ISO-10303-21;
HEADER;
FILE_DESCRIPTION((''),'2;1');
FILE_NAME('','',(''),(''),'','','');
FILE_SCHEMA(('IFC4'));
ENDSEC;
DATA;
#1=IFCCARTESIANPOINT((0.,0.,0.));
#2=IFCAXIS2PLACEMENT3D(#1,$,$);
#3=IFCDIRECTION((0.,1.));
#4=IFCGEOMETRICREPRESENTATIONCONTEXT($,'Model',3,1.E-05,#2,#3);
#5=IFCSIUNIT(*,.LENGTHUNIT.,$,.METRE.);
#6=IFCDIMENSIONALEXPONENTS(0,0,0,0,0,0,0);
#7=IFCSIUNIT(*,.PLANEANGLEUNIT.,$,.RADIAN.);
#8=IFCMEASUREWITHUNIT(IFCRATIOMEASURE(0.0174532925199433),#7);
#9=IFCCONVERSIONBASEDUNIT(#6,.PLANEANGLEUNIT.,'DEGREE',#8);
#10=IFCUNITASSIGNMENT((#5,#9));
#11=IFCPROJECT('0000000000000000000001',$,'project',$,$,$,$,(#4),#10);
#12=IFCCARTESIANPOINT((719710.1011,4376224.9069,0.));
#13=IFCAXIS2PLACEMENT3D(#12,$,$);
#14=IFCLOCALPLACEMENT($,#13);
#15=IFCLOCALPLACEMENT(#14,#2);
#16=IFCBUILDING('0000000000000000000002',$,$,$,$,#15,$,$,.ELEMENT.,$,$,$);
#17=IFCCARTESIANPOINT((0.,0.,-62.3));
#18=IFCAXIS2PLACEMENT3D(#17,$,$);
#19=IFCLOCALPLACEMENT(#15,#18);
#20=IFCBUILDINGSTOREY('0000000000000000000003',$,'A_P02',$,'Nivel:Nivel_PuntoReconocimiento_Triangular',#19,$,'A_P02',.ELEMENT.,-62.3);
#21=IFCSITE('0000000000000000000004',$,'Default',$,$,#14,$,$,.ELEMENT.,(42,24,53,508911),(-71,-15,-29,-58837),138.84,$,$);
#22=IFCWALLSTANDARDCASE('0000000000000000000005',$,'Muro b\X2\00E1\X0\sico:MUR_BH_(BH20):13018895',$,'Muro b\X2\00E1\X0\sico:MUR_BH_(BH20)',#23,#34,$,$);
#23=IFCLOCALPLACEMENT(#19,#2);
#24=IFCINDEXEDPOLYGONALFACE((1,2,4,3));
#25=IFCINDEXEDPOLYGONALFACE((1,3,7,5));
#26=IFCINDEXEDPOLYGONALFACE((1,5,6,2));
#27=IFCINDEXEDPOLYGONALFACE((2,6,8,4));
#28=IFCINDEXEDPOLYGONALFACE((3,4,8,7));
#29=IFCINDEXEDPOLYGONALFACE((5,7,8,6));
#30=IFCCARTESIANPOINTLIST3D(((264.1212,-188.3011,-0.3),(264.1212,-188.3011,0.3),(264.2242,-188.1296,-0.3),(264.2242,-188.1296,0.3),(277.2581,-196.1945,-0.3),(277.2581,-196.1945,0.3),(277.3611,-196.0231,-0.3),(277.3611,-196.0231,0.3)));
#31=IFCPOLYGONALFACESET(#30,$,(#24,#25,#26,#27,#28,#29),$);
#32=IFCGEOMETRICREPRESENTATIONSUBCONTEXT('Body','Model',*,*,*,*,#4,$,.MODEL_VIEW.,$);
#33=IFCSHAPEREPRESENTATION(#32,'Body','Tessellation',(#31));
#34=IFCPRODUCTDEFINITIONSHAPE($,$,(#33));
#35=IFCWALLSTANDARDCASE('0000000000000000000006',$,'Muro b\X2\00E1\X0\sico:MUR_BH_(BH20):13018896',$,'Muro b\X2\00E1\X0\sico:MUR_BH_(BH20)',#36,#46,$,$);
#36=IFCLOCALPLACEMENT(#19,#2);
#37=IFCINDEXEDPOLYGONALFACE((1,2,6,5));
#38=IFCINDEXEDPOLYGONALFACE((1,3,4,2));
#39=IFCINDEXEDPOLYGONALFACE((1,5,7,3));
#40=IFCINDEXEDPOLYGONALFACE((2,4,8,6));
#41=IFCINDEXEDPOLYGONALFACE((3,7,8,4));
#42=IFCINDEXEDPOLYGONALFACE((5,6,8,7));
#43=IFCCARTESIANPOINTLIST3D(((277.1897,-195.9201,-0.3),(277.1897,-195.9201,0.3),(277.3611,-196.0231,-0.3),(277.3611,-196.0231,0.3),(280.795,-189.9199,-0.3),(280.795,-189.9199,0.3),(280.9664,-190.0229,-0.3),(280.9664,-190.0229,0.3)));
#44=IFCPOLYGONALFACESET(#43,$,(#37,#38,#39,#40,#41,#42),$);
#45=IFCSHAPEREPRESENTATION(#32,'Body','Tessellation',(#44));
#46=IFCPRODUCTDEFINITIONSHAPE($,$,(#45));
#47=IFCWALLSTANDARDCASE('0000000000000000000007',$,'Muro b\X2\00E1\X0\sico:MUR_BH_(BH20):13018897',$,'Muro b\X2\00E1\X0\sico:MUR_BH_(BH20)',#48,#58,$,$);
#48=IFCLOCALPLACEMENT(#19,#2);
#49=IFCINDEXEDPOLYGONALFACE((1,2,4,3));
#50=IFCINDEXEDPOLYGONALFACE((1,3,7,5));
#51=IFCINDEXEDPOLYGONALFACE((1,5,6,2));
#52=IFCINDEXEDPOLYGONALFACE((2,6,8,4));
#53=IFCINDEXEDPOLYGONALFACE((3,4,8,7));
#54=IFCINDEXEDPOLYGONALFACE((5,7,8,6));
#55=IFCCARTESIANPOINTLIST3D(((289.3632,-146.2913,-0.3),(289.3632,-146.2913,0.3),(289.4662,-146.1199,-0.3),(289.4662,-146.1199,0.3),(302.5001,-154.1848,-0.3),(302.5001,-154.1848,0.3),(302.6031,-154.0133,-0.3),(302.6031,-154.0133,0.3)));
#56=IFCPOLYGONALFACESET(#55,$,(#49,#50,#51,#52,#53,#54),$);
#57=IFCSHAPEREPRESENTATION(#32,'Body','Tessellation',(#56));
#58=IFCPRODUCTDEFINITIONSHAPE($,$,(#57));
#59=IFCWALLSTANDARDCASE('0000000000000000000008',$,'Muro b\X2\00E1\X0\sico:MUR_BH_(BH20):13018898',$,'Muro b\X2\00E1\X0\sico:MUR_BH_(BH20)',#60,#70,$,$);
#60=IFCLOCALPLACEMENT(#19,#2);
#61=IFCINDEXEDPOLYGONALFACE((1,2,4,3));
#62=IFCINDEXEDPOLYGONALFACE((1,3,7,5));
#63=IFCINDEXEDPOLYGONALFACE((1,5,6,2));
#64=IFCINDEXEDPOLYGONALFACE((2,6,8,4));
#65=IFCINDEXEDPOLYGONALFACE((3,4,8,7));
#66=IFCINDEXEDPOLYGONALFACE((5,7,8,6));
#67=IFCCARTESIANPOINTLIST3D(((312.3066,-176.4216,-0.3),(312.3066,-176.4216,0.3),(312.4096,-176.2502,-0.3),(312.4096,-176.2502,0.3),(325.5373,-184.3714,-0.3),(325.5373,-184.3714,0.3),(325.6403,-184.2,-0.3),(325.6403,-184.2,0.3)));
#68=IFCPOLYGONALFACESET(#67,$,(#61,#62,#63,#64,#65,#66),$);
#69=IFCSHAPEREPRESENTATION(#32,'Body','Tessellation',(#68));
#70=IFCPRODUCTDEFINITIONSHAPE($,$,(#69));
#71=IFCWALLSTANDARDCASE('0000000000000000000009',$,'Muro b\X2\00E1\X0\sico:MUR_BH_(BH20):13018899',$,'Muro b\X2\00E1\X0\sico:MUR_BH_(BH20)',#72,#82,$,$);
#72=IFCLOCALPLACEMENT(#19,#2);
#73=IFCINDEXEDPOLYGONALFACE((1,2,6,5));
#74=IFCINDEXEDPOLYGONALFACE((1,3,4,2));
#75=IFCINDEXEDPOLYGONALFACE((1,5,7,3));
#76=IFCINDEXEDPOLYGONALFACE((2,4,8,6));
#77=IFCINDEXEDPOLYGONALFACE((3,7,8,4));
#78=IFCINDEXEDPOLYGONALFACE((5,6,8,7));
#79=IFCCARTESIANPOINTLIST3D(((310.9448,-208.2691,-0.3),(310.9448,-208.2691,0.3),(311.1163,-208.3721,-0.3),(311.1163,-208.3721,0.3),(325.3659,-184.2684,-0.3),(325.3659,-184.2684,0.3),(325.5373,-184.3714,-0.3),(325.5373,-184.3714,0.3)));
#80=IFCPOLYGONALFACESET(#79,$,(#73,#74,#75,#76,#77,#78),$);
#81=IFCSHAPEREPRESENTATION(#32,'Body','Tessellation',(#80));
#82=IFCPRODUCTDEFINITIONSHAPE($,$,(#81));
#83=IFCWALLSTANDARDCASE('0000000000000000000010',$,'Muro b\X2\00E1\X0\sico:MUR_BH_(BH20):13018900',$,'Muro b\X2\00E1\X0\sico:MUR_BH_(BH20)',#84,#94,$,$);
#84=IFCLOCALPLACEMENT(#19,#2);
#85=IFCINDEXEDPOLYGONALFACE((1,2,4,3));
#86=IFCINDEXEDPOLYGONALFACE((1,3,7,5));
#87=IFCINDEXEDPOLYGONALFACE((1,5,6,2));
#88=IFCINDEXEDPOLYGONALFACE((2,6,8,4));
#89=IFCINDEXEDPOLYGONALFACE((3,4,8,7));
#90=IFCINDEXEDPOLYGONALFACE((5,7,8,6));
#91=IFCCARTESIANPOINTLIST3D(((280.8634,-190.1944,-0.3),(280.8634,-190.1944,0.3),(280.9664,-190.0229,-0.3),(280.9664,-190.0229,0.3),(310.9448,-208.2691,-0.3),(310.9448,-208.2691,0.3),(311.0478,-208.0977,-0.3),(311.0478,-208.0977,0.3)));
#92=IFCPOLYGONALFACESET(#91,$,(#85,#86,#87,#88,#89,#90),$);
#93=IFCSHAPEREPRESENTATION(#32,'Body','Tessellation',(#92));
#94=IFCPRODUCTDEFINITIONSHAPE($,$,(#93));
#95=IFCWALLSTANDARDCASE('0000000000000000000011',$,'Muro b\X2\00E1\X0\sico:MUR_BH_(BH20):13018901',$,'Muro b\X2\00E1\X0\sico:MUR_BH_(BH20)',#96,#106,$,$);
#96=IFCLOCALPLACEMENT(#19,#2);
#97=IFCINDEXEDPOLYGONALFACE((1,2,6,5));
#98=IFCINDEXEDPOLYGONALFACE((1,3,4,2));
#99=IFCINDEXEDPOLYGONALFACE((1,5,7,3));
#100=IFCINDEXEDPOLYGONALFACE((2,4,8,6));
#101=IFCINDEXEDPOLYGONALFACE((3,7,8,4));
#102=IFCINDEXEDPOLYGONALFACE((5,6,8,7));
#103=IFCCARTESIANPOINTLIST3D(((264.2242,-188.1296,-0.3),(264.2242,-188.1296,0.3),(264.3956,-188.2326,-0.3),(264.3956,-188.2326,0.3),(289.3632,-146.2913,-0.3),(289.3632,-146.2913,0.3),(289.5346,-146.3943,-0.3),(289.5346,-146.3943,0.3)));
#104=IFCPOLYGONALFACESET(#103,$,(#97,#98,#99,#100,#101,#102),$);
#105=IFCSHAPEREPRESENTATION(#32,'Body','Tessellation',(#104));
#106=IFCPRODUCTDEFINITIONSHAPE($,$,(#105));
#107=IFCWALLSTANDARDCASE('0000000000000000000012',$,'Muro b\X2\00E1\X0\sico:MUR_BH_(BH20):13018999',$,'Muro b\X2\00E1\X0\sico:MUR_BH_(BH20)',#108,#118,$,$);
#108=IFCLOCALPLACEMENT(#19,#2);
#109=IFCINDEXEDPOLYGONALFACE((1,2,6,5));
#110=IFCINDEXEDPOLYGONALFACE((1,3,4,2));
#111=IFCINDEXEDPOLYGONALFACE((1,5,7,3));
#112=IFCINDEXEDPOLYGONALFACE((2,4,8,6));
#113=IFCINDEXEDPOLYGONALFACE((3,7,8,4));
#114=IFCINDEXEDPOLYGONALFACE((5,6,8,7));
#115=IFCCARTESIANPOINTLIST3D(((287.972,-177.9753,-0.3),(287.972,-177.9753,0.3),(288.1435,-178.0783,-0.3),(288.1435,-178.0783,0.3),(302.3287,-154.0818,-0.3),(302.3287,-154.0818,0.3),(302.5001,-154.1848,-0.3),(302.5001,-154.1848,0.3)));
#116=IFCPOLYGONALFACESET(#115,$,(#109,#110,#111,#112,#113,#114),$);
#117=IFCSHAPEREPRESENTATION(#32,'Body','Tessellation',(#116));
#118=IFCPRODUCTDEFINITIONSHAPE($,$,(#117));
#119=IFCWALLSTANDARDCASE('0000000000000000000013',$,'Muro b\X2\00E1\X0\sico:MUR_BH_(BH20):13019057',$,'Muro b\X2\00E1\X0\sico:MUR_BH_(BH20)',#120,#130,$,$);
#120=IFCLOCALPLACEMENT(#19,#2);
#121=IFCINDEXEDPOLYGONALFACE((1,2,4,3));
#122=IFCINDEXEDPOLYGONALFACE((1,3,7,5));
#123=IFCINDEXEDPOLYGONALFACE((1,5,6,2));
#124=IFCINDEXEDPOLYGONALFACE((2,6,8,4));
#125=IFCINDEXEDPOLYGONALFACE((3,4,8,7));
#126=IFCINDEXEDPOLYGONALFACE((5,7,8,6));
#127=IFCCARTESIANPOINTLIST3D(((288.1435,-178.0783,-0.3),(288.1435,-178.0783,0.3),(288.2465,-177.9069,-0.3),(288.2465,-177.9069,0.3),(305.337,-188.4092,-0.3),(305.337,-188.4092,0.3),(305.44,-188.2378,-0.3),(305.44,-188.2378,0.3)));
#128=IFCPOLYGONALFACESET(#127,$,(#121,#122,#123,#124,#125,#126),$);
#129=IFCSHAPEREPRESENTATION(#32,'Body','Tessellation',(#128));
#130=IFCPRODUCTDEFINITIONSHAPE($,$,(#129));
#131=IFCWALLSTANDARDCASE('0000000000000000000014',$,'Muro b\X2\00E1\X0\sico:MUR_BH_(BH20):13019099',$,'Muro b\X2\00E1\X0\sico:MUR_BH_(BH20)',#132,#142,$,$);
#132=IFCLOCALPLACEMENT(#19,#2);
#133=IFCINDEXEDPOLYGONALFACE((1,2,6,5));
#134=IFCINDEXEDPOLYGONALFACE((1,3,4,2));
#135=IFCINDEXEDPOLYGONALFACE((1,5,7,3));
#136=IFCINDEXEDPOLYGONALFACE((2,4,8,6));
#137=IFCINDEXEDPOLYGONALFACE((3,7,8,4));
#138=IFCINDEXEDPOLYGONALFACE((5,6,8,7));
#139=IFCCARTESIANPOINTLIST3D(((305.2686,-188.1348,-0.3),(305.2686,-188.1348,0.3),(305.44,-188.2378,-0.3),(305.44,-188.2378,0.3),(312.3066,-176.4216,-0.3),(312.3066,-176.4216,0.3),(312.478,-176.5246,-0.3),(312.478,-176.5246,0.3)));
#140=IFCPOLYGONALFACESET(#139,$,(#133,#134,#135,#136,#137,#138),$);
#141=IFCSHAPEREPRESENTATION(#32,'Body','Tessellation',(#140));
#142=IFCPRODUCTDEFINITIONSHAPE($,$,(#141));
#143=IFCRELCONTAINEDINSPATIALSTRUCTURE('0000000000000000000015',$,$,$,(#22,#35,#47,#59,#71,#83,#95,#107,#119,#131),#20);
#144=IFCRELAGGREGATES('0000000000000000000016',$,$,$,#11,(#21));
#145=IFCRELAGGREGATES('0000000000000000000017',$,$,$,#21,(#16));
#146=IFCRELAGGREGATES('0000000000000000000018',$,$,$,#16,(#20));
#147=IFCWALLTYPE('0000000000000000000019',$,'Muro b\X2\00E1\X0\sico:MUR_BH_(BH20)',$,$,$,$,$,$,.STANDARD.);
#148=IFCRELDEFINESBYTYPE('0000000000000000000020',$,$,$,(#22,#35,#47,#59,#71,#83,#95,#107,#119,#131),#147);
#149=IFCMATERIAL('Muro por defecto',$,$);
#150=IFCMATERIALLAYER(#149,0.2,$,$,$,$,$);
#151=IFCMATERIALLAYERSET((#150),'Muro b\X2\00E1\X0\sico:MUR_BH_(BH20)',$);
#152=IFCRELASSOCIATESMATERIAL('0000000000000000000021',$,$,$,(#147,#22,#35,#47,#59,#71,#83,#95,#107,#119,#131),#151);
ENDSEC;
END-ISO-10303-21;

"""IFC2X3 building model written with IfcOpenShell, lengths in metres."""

from ifc_helpers import new_model, entity, si_unit, converted_unit, direction, frame, frame_2d, origin, place, context, subcontext, project, spatial, rectangle, extrude, material, layer, layer_set, layer_usage, type_object, element, save


model = new_model("IFC2X3")

# Units and contexts
model_context = context("Model", 3, precision=1e-05, world=origin(), true_north=direction((0.0, 1.0)))
body_context = subcontext(model_context, "Body", "Model", "MODEL_VIEW")
ifc_project = project(units=[si_unit("LENGTHUNIT", "METRE"), converted_unit("PLANEANGLEUNIT", "DEGREE", entity("IfcRatioMeasure", 0.0174532925199433), si_unit("PLANEANGLEUNIT", "RADIAN"), dimensions=[0, 0, 0, 0, 0, 0, 0])], contexts=[model_context])

# Site, building, storey
site_placement = place(None, frame((719710.1011, 4376224.9069, 0.0)))
site = spatial("IfcSite", under=ifc_project, at=site_placement, Name="Default", CompositionType="ELEMENT", RefLatitude=(42, 24, 53, 508911), RefLongitude=(-71, -15, -29, -58837), RefElevation=138.84)
building_placement = place(site_placement, origin())
building = spatial("IfcBuilding", under=site, at=building_placement, CompositionType="ELEMENT")
storey_placement = place(building_placement, frame((0.0, 0.0, -62.3)))
storey = spatial("IfcBuildingStorey", under=building, at=storey_placement, Name="A_P02", ObjectType="Nivel:Nivel_PuntoReconocimiento_Triangular", LongName="A_P02", CompositionType="ELEMENT", Elevation=-62.3)

# Walls
ifc_material_1 = material(Name="Muro por defecto")
ifc_layer_1 = layer(ifc_material_1, 0.2)
ifc_layer_set_1 = layer_set([ifc_layer_1], Name="Muro básico:MUR_BH_(BH20)")
ifc_layer_usage_1 = layer_usage(ifc_layer_set_1, "AXIS2", "NEGATIVE", 0.1)
wall_type = type_object("IfcWallType", Name="Muro básico:MUR_BH_(BH20)", PredefinedType="STANDARD", material=ifc_layer_set_1)
wall_1_placement = place(storey_placement, frame((277.3096, -196.1088, -0.3), z_axis=(0.0, 0.0, 1.0), x_axis=(-0.857167, 0.515038, 0.0)))
element("IfcWallStandardCase", 1, at=wall_1_placement, inside=storey, type_object=wall_type, material=ifc_layer_usage_1, Name="Muro básico:MUR_BH_(BH20):13018895", ObjectType="Muro básico:MUR_BH_(BH20)", context=body_context, shape_type="SweptSolid", body=[
    extrude(rectangle(XDim=15.326, YDim=0.2, at=frame_2d((7.663, 0.0), x_axis=(-1.0, 0.0))), origin(), (0.0, 0.0, 1.0), 0.6),
])
ifc_layer_usage_2 = layer_usage(ifc_layer_set_1, "AXIS2", "NEGATIVE", 0.1)
wall_2_placement = place(storey_placement, frame((280.8807, -189.9714, -0.3), z_axis=(0.0, 0.0, 1.0), x_axis=(-0.515038, -0.857167, 0.0)))
element("IfcWallStandardCase", 2, at=wall_2_placement, inside=storey, type_object=wall_type, material=ifc_layer_usage_2, Name="Muro básico:MUR_BH_(BH20):13018896", ObjectType="Muro básico:MUR_BH_(BH20)", context=body_context, shape_type="SweptSolid", body=[
    extrude(rectangle(XDim=7.0, YDim=0.2, at=frame_2d((3.5, 0.0), x_axis=(-1.0, 0.0))), origin(), (0.0, 0.0, 1.0), 0.6),
])
ifc_layer_usage_3 = layer_usage(ifc_layer_set_1, "AXIS2", "NEGATIVE", 0.1)
wall_3_placement = place(storey_placement, frame((302.5516, -154.099, -0.3), z_axis=(0.0, 0.0, 1.0), x_axis=(-0.857167, 0.515038, 0.0)))
element("IfcWallStandardCase", 3, at=wall_3_placement, inside=storey, type_object=wall_type, material=ifc_layer_usage_3, Name="Muro básico:MUR_BH_(BH20):13018897", ObjectType="Muro básico:MUR_BH_(BH20)", context=body_context, shape_type="SweptSolid", body=[
    extrude(rectangle(XDim=15.326, YDim=0.2, at=frame_2d((7.663, 0.0), x_axis=(-1.0, 0.0))), origin(), (0.0, 0.0, 1.0), 0.6),
])
ifc_layer_usage_4 = layer_usage(ifc_layer_set_1, "AXIS2", "NEGATIVE", 0.1)
wall_4_placement = place(storey_placement, frame((312.3581, -176.3359, -0.3), z_axis=(0.0, 0.0, 1.0), x_axis=(0.857167, -0.515038, 0.0)))
element("IfcWallStandardCase", 4, at=wall_4_placement, inside=storey, type_object=wall_type, material=ifc_layer_usage_4, Name="Muro básico:MUR_BH_(BH20):13018898", ObjectType="Muro básico:MUR_BH_(BH20)", context=body_context, shape_type="SweptSolid", body=[
    extrude(rectangle(XDim=15.4354, YDim=0.2, at=frame_2d((7.7177, 0.0), x_axis=(-1.0, 0.0))), origin(), (0.0, 0.0, 1.0), 0.6),
])
ifc_layer_usage_5 = layer_usage(ifc_layer_set_1, "AXIS2", "NEGATIVE", 0.1)
wall_5_placement = place(storey_placement, frame((325.4516, -184.3199, -0.3), z_axis=(0.0, 0.0, 1.0), x_axis=(-0.515038, -0.857167, 0.0)))
element("IfcWallStandardCase", 5, at=wall_5_placement, inside=storey, type_object=wall_type, material=ifc_layer_usage_5, Name="Muro básico:MUR_BH_(BH20):13018899", ObjectType="Muro básico:MUR_BH_(BH20)", context=body_context, shape_type="SweptSolid", body=[
    extrude(rectangle(XDim=28.0, YDim=0.2, at=frame_2d((14.0, 0.0), x_axis=(-1.0, 0.0))), origin(), (0.0, 0.0, 1.0), 0.6),
])
ifc_layer_usage_6 = layer_usage(ifc_layer_set_1, "AXIS2", "NEGATIVE", 0.1)
wall_6_placement = place(storey_placement, frame((310.9963, -208.1834, -0.3), z_axis=(0.0, 0.0, 1.0), x_axis=(-0.857167, 0.515038, 0.0)))
element("IfcWallStandardCase", 6, at=wall_6_placement, inside=storey, type_object=wall_type, material=ifc_layer_usage_6, Name="Muro básico:MUR_BH_(BH20):13018900", ObjectType="Muro básico:MUR_BH_(BH20)", context=body_context, shape_type="SweptSolid", body=[
    extrude(rectangle(XDim=35.094, YDim=0.2, at=frame_2d((17.547, 0.0), x_axis=(-1.0, 0.0))), origin(), (0.0, 0.0, 1.0), 0.6),
])
ifc_layer_usage_7 = layer_usage(ifc_layer_set_1, "AXIS2", "NEGATIVE", 0.1)
wall_7_placement = place(storey_placement, frame((264.3099, -188.1811, -0.3), z_axis=(0.0, 0.0, 1.0), x_axis=(0.515038, 0.857167, 0.0)))
element("IfcWallStandardCase", 7, at=wall_7_placement, inside=storey, type_object=wall_type, material=ifc_layer_usage_7, Name="Muro básico:MUR_BH_(BH20):13018901", ObjectType="Muro básico:MUR_BH_(BH20)", context=body_context, shape_type="SweptSolid", body=[
    extrude(rectangle(XDim=48.81, YDim=0.2, at=frame_2d((24.405, 0.0), x_axis=(-1.0, 0.0))), origin(), (0.0, 0.0, 1.0), 0.6),
])
ifc_layer_usage_8 = layer_usage(ifc_layer_set_1, "AXIS2", "NEGATIVE", 0.1)
wall_8_placement = place(storey_placement, frame((302.4144, -154.1333, -0.3), z_axis=(0.0, 0.0, 1.0), x_axis=(-0.515038, -0.857167, 0.0)))
element("IfcWallStandardCase", 8, at=wall_8_placement, inside=storey, type_object=wall_type, material=ifc_layer_usage_8, Name="Muro básico:MUR_BH_(BH20):13018999", ObjectType="Muro básico:MUR_BH_(BH20)", context=body_context, shape_type="SweptSolid", body=[
    extrude(rectangle(XDim=27.875, YDim=0.2, at=frame_2d((13.9375, 0.0), x_axis=(-1.0, 0.0))), origin(), (0.0, 0.0, 1.0), 0.6),
])
ifc_layer_usage_9 = layer_usage(ifc_layer_set_1, "AXIS2", "NEGATIVE", 0.1)
wall_9_placement = place(storey_placement, frame((288.195, -177.9926, -0.3), z_axis=(0.0, 0.0, 1.0), x_axis=(0.857167, -0.515038, 0.0)))
element("IfcWallStandardCase", 9, at=wall_9_placement, inside=storey, type_object=wall_type, material=ifc_layer_usage_9, Name="Muro básico:MUR_BH_(BH20):13019057", ObjectType="Muro básico:MUR_BH_(BH20)", context=body_context, shape_type="SweptSolid", body=[
    extrude(rectangle(XDim=20.0586, YDim=0.2, at=frame_2d((10.0293, 0.0), x_axis=(-1.0, 0.0))), origin(), (0.0, 0.0, 1.0), 0.6),
])
ifc_layer_usage_10 = layer_usage(ifc_layer_set_1, "AXIS2", "NEGATIVE", 0.1)
wall_10_placement = place(storey_placement, frame((305.3543, -188.1863, -0.3), z_axis=(0.0, 0.0, 1.0), x_axis=(0.515038, 0.857167, 0.0)))
element("IfcWallStandardCase", 10, at=wall_10_placement, inside=storey, type_object=wall_type, material=ifc_layer_usage_10, Name="Muro básico:MUR_BH_(BH20):13019099", ObjectType="Muro básico:MUR_BH_(BH20)", context=body_context, shape_type="SweptSolid", body=[
    extrude(rectangle(XDim=13.665, YDim=0.2, at=frame_2d((6.8325, 0.0), x_axis=(-1.0, 0.0))), origin(), (0.0, 0.0, 1.0), 0.6),
])

save(model, "model.ifc")
